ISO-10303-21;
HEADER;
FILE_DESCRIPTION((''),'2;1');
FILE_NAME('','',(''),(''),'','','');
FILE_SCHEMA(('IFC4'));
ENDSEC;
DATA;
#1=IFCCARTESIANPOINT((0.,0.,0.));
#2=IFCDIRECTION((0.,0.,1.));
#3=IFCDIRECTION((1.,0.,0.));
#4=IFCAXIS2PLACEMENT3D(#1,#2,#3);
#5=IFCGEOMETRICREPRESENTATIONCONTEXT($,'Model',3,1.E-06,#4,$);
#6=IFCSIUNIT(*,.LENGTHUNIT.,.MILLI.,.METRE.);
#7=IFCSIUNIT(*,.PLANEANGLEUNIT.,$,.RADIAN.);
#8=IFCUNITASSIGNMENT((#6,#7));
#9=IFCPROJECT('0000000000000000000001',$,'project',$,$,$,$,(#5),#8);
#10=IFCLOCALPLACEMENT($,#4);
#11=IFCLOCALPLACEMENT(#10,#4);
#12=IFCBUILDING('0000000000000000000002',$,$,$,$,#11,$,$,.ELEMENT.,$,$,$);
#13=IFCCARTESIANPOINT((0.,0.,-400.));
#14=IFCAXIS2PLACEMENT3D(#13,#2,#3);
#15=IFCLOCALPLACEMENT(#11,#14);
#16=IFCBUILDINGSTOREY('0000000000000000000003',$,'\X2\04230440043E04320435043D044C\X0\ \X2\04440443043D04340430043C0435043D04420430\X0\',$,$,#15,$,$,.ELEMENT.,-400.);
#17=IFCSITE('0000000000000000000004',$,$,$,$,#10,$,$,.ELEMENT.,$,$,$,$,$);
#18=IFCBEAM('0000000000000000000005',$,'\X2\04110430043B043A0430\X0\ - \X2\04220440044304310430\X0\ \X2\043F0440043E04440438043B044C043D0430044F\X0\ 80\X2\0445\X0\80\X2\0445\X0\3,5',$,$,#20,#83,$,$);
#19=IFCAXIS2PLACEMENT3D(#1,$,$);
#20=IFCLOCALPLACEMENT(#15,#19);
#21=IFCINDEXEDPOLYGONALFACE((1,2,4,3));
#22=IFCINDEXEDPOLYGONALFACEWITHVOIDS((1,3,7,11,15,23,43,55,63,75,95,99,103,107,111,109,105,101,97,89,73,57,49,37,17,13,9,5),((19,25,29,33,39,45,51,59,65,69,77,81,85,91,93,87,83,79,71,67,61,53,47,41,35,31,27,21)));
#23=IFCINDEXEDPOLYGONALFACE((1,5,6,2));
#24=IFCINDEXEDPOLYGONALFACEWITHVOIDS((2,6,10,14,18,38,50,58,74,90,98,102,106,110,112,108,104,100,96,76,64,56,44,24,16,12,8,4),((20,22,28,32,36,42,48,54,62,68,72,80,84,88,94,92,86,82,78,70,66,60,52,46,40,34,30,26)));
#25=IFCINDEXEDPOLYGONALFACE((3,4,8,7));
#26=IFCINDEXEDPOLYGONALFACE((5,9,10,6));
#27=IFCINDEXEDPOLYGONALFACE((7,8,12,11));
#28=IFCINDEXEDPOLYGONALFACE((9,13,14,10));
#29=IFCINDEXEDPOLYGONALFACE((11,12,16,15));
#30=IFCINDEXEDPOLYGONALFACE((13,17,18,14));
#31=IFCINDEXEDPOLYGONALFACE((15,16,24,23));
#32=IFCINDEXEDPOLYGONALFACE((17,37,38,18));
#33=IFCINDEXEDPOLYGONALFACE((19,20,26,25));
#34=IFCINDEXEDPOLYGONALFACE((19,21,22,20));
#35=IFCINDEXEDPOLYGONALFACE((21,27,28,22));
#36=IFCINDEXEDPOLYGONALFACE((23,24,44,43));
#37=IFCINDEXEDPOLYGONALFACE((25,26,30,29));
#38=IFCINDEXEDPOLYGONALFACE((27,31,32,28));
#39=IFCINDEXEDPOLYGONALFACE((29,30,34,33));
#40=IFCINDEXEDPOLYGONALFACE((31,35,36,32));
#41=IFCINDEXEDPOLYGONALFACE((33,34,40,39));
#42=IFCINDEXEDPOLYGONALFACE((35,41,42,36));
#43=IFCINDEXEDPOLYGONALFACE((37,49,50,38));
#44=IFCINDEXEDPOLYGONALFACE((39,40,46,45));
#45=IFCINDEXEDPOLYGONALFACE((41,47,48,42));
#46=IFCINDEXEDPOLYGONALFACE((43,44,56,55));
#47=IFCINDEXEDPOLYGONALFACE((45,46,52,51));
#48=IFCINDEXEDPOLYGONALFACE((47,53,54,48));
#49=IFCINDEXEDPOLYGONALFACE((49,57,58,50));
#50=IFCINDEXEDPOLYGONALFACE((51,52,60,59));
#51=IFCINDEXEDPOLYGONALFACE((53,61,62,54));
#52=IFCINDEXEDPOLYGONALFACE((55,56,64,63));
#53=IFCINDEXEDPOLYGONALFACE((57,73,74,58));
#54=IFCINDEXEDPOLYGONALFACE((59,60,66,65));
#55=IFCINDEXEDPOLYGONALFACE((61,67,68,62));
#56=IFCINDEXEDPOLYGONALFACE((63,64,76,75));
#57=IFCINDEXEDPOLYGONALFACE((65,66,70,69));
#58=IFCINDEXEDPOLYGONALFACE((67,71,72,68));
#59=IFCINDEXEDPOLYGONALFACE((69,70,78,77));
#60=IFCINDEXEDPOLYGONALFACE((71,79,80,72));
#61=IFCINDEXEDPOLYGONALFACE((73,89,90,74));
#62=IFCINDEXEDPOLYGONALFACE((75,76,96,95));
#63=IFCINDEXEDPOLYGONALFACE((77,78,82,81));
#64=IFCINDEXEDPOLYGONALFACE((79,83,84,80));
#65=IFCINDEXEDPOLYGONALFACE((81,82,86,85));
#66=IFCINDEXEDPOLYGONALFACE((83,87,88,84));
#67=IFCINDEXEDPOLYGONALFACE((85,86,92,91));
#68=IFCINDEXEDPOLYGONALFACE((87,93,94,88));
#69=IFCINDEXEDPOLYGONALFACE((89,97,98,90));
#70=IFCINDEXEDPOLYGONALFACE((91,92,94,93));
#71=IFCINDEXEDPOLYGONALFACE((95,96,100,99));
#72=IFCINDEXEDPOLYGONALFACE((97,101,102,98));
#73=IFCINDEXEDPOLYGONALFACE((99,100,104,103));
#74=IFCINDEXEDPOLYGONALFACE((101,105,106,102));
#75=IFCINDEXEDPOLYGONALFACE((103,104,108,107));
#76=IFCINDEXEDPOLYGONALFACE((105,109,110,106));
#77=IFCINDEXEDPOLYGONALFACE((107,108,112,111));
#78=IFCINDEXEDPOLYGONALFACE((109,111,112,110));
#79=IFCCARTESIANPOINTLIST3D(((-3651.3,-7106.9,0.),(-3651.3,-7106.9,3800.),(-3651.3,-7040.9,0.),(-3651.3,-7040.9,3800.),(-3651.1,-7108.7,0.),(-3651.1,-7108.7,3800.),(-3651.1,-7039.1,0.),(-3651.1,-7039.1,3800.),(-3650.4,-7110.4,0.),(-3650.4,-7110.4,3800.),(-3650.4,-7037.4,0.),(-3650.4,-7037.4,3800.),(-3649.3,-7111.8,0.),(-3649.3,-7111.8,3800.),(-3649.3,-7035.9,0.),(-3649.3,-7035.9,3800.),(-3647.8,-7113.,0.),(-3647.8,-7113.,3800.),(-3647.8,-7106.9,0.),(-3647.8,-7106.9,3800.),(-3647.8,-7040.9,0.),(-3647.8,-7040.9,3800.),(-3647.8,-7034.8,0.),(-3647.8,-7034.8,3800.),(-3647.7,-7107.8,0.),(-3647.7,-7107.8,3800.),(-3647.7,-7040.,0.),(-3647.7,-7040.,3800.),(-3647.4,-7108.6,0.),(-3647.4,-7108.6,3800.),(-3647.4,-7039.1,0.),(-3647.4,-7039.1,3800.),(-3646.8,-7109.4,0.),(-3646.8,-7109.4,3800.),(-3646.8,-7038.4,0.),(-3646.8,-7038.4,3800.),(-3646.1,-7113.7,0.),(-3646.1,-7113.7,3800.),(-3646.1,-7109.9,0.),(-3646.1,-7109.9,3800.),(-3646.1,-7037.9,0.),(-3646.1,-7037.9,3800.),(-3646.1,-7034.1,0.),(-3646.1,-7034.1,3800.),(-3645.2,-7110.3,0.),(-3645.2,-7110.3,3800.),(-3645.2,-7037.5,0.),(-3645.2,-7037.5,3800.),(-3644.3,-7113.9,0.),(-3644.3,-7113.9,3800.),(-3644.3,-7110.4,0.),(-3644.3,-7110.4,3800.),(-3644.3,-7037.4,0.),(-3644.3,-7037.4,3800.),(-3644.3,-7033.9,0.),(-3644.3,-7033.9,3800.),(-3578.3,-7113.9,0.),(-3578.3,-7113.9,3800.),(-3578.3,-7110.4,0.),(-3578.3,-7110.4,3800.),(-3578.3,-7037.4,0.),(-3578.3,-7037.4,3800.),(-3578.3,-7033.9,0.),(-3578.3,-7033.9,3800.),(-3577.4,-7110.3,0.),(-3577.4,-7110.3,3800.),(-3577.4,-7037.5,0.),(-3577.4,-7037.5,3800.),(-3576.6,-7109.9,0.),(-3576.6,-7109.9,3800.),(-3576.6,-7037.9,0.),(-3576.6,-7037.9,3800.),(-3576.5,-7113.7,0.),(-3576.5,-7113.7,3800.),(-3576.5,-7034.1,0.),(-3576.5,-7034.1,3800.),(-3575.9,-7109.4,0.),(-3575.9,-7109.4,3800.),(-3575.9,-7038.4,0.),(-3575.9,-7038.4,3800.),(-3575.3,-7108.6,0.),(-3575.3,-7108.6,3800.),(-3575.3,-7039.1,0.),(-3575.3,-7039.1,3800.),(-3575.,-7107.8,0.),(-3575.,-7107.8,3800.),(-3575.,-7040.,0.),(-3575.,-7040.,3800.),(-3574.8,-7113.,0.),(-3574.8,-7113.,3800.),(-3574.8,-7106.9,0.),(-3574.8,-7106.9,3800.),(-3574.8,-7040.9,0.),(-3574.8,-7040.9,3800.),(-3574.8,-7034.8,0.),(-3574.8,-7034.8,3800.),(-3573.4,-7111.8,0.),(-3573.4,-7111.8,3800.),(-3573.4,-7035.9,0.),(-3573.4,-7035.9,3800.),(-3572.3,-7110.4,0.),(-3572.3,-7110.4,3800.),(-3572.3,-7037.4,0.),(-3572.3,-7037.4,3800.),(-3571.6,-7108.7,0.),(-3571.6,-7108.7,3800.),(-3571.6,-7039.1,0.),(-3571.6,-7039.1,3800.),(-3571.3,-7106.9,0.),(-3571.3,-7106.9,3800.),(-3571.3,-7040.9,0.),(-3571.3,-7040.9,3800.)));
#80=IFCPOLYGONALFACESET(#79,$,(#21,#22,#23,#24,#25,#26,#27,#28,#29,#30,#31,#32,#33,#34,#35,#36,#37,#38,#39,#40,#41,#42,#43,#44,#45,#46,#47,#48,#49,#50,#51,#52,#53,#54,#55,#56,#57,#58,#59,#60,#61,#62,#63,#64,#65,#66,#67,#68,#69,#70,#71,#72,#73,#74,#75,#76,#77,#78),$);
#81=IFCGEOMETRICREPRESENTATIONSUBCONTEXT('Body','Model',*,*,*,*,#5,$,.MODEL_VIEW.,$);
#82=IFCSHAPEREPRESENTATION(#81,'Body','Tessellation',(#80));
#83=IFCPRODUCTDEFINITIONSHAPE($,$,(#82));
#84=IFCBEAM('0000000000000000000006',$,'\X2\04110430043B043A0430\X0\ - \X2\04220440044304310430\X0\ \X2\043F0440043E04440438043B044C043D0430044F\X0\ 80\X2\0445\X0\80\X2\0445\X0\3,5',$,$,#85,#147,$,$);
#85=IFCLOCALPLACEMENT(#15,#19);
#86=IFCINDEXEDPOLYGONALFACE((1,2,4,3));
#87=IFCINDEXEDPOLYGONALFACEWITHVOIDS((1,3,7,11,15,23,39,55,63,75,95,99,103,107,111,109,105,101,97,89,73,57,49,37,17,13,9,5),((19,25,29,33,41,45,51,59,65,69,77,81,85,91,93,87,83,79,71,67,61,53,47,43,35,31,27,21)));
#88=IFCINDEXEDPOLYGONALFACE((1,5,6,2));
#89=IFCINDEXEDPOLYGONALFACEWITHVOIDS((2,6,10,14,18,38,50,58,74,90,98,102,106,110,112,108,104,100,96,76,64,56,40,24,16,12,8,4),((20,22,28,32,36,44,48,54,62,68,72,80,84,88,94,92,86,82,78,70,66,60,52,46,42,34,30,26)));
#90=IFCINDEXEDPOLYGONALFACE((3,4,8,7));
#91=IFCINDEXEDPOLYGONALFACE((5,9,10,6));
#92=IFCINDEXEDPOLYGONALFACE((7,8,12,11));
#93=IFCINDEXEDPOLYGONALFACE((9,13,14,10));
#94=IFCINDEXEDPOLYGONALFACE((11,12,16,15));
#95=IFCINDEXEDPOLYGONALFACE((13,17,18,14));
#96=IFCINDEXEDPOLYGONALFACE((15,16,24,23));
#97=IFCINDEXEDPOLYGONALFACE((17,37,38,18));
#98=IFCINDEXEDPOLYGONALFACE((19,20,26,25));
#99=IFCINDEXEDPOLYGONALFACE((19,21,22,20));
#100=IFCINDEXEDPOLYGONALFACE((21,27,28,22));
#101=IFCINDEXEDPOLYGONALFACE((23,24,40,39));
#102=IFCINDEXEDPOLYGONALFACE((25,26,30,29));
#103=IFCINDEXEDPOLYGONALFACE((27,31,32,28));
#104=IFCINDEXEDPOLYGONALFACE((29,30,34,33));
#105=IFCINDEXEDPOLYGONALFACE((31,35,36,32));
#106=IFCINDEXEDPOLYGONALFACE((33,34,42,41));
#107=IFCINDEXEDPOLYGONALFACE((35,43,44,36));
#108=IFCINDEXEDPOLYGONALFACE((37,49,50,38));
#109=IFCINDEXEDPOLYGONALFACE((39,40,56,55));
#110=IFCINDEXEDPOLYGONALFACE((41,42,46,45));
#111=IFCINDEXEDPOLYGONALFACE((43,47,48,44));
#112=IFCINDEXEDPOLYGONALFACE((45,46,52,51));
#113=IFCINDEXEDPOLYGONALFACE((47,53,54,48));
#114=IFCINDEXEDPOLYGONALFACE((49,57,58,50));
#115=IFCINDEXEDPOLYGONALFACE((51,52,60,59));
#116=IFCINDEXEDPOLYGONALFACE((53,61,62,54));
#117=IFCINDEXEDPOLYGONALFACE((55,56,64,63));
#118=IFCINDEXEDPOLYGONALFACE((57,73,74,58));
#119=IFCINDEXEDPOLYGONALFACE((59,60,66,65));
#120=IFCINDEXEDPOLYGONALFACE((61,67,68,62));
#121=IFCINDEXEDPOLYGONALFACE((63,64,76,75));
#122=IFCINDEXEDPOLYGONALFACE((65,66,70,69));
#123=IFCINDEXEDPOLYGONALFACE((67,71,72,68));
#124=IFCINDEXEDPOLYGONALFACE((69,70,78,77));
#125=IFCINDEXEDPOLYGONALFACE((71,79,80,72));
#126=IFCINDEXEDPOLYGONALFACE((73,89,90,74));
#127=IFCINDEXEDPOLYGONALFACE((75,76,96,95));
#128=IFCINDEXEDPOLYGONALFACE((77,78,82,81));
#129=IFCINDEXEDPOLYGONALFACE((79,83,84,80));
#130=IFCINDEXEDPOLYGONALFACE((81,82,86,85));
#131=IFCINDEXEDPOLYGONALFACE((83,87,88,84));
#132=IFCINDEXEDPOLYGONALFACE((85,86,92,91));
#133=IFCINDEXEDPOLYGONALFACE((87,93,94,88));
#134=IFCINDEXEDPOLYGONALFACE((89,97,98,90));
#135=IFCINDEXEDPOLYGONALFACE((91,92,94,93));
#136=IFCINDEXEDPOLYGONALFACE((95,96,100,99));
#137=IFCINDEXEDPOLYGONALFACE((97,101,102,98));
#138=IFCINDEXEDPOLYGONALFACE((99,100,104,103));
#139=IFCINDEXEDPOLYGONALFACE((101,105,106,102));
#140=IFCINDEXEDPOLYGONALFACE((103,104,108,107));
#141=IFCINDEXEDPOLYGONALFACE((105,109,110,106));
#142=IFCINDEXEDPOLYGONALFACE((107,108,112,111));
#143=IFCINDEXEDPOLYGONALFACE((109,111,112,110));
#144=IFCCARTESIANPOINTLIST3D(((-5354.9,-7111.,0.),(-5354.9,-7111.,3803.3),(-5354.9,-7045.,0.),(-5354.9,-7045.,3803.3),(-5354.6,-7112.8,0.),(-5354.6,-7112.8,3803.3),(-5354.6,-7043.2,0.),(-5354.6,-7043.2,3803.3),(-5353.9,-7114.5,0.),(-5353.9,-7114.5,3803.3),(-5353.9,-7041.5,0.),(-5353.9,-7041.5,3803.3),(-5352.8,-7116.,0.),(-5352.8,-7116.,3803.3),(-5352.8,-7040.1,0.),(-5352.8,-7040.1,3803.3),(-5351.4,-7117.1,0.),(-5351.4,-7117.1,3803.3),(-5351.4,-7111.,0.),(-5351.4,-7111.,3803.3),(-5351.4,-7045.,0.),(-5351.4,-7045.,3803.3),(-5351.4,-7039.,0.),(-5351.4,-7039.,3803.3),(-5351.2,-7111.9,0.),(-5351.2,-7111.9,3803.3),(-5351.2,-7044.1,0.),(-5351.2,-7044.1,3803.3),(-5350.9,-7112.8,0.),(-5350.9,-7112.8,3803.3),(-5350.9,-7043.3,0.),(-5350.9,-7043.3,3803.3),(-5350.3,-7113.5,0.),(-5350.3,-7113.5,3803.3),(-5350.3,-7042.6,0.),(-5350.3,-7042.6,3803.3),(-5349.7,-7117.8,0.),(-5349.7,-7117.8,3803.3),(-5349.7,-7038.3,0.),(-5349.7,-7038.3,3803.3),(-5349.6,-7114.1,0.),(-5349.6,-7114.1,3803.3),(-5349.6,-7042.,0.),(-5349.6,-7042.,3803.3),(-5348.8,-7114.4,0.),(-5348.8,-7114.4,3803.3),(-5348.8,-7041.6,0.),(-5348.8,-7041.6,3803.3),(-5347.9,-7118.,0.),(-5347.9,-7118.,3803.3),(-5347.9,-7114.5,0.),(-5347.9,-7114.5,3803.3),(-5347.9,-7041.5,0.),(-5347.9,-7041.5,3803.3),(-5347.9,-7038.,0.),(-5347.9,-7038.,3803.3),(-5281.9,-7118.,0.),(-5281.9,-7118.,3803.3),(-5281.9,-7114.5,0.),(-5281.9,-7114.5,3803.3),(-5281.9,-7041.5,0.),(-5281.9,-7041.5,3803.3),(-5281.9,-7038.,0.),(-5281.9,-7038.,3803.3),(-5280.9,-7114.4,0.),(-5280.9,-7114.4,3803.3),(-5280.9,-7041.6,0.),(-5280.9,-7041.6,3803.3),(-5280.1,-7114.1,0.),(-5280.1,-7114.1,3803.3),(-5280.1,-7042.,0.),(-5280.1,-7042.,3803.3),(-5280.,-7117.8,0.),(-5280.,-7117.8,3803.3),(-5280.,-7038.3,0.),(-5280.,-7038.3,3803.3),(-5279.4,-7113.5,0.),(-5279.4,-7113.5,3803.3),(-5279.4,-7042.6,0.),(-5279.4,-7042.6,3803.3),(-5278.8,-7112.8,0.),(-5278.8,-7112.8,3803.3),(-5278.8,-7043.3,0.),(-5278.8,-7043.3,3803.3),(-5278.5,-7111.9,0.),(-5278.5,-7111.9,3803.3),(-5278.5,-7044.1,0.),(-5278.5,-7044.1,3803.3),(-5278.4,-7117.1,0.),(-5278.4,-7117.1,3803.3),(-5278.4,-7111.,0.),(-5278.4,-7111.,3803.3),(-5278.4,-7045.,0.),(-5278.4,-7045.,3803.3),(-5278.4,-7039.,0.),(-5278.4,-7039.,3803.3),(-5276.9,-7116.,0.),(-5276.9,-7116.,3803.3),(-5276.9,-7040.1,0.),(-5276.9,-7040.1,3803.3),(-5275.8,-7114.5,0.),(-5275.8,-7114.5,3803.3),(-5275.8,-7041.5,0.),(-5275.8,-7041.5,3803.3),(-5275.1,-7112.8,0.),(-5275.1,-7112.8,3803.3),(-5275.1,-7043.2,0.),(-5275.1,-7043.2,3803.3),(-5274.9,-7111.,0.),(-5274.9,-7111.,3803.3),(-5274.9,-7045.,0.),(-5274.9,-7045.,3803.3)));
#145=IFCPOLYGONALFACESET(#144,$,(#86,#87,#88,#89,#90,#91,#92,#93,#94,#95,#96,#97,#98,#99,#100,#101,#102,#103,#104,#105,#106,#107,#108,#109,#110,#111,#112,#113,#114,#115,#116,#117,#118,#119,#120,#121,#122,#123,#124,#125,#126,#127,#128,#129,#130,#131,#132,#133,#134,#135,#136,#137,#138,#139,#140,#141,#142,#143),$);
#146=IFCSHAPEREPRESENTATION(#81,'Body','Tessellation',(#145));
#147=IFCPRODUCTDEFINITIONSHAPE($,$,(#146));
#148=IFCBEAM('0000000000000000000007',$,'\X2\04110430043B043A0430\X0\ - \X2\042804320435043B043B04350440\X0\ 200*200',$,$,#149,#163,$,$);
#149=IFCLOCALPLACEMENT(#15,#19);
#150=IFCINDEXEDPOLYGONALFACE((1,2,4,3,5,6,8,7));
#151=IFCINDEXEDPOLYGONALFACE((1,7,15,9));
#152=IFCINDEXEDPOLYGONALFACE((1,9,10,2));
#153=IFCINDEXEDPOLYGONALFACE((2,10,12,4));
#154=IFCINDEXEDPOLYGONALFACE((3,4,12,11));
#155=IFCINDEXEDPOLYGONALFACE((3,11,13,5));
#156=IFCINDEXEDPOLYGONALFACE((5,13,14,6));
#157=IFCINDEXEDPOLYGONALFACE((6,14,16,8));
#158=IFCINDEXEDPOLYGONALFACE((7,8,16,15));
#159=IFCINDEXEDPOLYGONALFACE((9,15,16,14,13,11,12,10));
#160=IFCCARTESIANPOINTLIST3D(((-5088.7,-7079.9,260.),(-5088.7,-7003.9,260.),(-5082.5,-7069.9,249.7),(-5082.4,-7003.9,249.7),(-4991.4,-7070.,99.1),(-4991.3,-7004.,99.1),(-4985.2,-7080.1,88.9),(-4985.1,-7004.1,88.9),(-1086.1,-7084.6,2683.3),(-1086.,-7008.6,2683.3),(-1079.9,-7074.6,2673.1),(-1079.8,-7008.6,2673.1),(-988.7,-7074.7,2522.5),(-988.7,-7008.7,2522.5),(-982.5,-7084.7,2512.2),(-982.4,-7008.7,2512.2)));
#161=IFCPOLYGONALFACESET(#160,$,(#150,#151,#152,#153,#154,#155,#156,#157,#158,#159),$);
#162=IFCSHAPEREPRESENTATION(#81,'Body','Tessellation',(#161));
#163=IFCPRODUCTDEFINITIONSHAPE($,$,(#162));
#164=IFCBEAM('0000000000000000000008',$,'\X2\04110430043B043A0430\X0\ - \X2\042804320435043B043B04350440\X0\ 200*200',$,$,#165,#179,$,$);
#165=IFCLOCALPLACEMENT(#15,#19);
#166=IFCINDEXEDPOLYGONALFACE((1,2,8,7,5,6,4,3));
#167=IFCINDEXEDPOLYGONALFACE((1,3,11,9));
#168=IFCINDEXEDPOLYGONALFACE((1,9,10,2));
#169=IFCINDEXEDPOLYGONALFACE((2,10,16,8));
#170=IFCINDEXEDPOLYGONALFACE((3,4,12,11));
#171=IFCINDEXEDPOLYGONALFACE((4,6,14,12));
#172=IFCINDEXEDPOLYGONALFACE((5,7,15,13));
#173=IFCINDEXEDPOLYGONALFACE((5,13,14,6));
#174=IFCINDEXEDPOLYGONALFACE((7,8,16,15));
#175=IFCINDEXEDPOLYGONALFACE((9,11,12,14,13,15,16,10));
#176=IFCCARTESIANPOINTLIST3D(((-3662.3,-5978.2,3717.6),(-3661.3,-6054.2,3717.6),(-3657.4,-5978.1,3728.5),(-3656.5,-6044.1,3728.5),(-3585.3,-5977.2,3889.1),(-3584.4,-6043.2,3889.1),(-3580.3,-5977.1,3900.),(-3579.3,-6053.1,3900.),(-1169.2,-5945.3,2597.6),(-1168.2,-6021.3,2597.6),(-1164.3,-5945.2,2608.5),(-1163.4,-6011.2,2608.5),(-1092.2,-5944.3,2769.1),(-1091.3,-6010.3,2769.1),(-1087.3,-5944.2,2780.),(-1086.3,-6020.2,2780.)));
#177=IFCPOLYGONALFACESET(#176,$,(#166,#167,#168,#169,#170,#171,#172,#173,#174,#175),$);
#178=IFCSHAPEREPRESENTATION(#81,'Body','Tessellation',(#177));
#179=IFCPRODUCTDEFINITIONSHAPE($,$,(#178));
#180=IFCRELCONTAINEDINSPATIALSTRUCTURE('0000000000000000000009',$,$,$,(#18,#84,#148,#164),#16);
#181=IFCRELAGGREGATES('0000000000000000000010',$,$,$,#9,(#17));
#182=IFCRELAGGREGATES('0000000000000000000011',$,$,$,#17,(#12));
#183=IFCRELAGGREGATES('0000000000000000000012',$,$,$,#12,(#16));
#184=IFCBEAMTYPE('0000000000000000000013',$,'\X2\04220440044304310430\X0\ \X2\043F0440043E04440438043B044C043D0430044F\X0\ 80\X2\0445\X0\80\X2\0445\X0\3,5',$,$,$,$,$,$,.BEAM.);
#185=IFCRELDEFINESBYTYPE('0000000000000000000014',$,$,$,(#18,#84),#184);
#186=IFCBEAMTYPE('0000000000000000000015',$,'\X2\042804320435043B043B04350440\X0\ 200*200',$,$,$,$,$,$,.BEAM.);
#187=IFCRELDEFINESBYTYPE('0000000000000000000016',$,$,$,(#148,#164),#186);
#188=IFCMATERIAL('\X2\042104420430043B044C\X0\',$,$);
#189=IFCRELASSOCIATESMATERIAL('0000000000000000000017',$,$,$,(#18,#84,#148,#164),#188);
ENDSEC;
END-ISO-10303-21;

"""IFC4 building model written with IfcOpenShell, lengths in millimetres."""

from ifc_helpers import new_model, si_unit, frame, origin_with_axes, place, context, subcontext, project, spatial, line, arc, indexed_curve, outline, extrude, source, transform, mapped, material, type_object, element, save


model = new_model("IFC4")

# Units and contexts
model_context = context("Model", 3, precision=1e-06, world=origin_with_axes())
body_context = subcontext(model_context, "Body", "Model", "MODEL_VIEW")
ifc_project = project(units=[si_unit("LENGTHUNIT", "METRE", prefix="MILLI"), si_unit("PLANEANGLEUNIT", "RADIAN")], contexts=[model_context])

# Site, building, storey
site_placement = place(None, origin_with_axes())
site = spatial("IfcSite", under=ifc_project, at=site_placement, CompositionType="ELEMENT")
building_placement = place(site_placement, origin_with_axes())
building = spatial("IfcBuilding", under=site, at=building_placement, CompositionType="ELEMENT")
storey_placement = place(building_placement, frame((0.0, 0.0, -400.0), z_axis=(0.0, 0.0, 1.0), x_axis=(1.0, 0.0, 0.0)))
storey = spatial("IfcBuildingStorey", under=building, at=storey_placement, Name="Уровень фундамента", CompositionType="ELEMENT", Elevation=-400.0)

# Beams
beam_type_1 = type_object("IfcBeamType", Name="Труба профильная 80х80х3,5", PredefinedType="BEAM")
ifc_material_1 = material(Name="Сталь")
shared_shape_1 = source(origin_with_axes(), body_context, "Body", "SweptSolid", [
    extrude(outline(indexed_curve([(-40.0, -73.0), (-37.9, -77.9), (-33.0, -80.0), (33.0, -80.0), (37.9, -77.9), (40.0, -73.0), (40.0, -7.0), (37.9, -2.1), (33.0, 0.0), (-33.0, 0.0), (-37.9, -2.1), (-40.0, -7.0)], segments=[arc(1, 2, 3), line(3, 4), arc(4, 5, 6), line(6, 7), arc(7, 8, 9), line(9, 10), arc(10, 11, 12), line(12, 1)]), holes=[indexed_curve([(-36.5, -7.0), (-35.5, -4.5), (-33.0, -3.5), (33.0, -3.5), (35.5, -4.5), (36.5, -7.0), (36.5, -73.0), (35.5, -75.5), (33.0, -76.5), (-33.0, -76.5), (-35.5, -75.5), (-36.5, -73.0)], segments=[arc(1, 2, 3), line(3, 4), arc(4, 5, 6), line(6, 7), arc(7, 8, 9), line(9, 10), arc(10, 11, 12), line(12, 1)])]), origin_with_axes(), (0.0, 0.0, -1.0), 3800.0),
])
beam_1_placement = place(storey_placement, frame((-3611.3, -7033.9, 3800.0), z_axis=(0.0, 0.0, 1.0), x_axis=(1.0, 0.0, 0.0)))
element("IfcBeam", 1, at=beam_1_placement, inside=storey, type_object=beam_type_1, material=ifc_material_1, Name="Балка - Труба профильная 80х80х3,5", context=body_context, shape_type="MappedRepresentation", body=[
    mapped(shared_shape_1, transform((0.0, 0.0, 0.0), x_axis=(1.0, 0.0, 0.0), y_axis=(0.0, 1.0, 0.0), z_axis=(0.0, 0.0, 1.0), scale=1.0)),
])
shared_shape_2 = source(origin_with_axes(), body_context, "Body", "SweptSolid", [
    extrude(outline(indexed_curve([(-40.0, -73.0), (-37.9, -77.9), (-33.0, -80.0), (33.0, -80.0), (37.9, -77.9), (40.0, -73.0), (40.0, -7.0), (37.9, -2.1), (33.0, 0.0), (-33.0, 0.0), (-37.9, -2.1), (-40.0, -7.0)], segments=[arc(1, 2, 3), line(3, 4), arc(4, 5, 6), line(6, 7), arc(7, 8, 9), line(9, 10), arc(10, 11, 12), line(12, 1)]), holes=[indexed_curve([(-36.5, -7.0), (-35.5, -4.5), (-33.0, -3.5), (33.0, -3.5), (35.5, -4.5), (36.5, -7.0), (36.5, -73.0), (35.5, -75.5), (33.0, -76.5), (-33.0, -76.5), (-35.5, -75.5), (-36.5, -73.0)], segments=[arc(1, 2, 3), line(3, 4), arc(4, 5, 6), line(6, 7), arc(7, 8, 9), line(9, 10), arc(10, 11, 12), line(12, 1)])]), origin_with_axes(), (0.0, 0.0, -1.0), 3803.3),
])
beam_2_placement = place(storey_placement, frame((-5314.9, -7038.0, 3803.3), z_axis=(0.0, 0.0, 1.0), x_axis=(1.0, 0.0, 0.0)))
element("IfcBeam", 2, at=beam_2_placement, inside=storey, type_object=beam_type_1, material=ifc_material_1, Name="Балка - Труба профильная 80х80х3,5", context=body_context, shape_type="MappedRepresentation", body=[
    mapped(shared_shape_2, transform((0.0, 0.0, 0.0), x_axis=(1.0, 0.0, 0.0), y_axis=(0.0, 1.0, 0.0), z_axis=(0.0, 0.0, 1.0), scale=1.0)),
])
beam_type_2 = type_object("IfcBeamType", Name="Швеллер 200*200", PredefinedType="BEAM")
shared_shape_3 = source(origin_with_axes(), body_context, "Body", "SweptSolid", [
    extrude(outline(indexed_curve([(-38.0, 0.0), (38.0, 0.0), (38.0, 12.0), (-28.0, 12.0), (-28.0, 188.0), (38.0, 188.0), (38.0, 200.0), (-38.0, 200.0)], segments=[line(1, 2), line(2, 3), line(3, 4), line(4, 5), line(5, 6), line(6, 7), line(7, 8), line(8, 1)])), origin_with_axes(), (0.0, 0.0, -1.0), 4679.1),
])
beam_3_placement = place(storey_placement, frame((-5088.7, -7041.9, 260.0), z_axis=(-0.855431, 0.00099, -0.517916), x_axis=(0.001158, 0.999999, 0.0)))
element("IfcBeam", 3, at=beam_3_placement, inside=storey, type_object=beam_type_2, material=ifc_material_1, Name="Балка - Швеллер 200*200", context=body_context, shape_type="MappedRepresentation", body=[
    mapped(shared_shape_3, transform((0.0, 0.0, 0.0), x_axis=(1.0, 0.0, 0.0), y_axis=(0.0, 1.0, 0.0), z_axis=(0.0, 0.0, 1.0), scale=1.0)),
])
shared_shape_4 = source(origin_with_axes(), body_context, "Body", "SweptSolid", [
    extrude(outline(indexed_curve([(-38.0, 0.0), (38.0, 0.0), (38.0, 12.0), (-28.0, 12.0), (-28.0, 188.0), (38.0, 188.0), (38.0, 200.0), (-38.0, 200.0)], segments=[line(1, 2), line(2, 3), line(3, 4), line(4, 5), line(5, 6), line(6, 7), line(7, 8), line(8, 1)])), origin_with_axes(), (0.0, 0.0, -1.0), 2733.3),
])
beam_4_placement = place(storey_placement, frame((-3579.8, -6015.1, 3900.0), z_axis=(-0.912113, -0.012045, 0.409762), x_axis=(-0.013204, 0.999913, 0.0)))
element("IfcBeam", 4, at=beam_4_placement, inside=storey, type_object=beam_type_2, material=ifc_material_1, Name="Балка - Швеллер 200*200", context=body_context, shape_type="MappedRepresentation", body=[
    mapped(shared_shape_4, transform((0.0, 0.0, 0.0), x_axis=(1.0, 0.0, 0.0), y_axis=(0.0, 1.0, 0.0), z_axis=(0.0, 0.0, 1.0), scale=1.0)),
])

save(model, "model.ifc")
